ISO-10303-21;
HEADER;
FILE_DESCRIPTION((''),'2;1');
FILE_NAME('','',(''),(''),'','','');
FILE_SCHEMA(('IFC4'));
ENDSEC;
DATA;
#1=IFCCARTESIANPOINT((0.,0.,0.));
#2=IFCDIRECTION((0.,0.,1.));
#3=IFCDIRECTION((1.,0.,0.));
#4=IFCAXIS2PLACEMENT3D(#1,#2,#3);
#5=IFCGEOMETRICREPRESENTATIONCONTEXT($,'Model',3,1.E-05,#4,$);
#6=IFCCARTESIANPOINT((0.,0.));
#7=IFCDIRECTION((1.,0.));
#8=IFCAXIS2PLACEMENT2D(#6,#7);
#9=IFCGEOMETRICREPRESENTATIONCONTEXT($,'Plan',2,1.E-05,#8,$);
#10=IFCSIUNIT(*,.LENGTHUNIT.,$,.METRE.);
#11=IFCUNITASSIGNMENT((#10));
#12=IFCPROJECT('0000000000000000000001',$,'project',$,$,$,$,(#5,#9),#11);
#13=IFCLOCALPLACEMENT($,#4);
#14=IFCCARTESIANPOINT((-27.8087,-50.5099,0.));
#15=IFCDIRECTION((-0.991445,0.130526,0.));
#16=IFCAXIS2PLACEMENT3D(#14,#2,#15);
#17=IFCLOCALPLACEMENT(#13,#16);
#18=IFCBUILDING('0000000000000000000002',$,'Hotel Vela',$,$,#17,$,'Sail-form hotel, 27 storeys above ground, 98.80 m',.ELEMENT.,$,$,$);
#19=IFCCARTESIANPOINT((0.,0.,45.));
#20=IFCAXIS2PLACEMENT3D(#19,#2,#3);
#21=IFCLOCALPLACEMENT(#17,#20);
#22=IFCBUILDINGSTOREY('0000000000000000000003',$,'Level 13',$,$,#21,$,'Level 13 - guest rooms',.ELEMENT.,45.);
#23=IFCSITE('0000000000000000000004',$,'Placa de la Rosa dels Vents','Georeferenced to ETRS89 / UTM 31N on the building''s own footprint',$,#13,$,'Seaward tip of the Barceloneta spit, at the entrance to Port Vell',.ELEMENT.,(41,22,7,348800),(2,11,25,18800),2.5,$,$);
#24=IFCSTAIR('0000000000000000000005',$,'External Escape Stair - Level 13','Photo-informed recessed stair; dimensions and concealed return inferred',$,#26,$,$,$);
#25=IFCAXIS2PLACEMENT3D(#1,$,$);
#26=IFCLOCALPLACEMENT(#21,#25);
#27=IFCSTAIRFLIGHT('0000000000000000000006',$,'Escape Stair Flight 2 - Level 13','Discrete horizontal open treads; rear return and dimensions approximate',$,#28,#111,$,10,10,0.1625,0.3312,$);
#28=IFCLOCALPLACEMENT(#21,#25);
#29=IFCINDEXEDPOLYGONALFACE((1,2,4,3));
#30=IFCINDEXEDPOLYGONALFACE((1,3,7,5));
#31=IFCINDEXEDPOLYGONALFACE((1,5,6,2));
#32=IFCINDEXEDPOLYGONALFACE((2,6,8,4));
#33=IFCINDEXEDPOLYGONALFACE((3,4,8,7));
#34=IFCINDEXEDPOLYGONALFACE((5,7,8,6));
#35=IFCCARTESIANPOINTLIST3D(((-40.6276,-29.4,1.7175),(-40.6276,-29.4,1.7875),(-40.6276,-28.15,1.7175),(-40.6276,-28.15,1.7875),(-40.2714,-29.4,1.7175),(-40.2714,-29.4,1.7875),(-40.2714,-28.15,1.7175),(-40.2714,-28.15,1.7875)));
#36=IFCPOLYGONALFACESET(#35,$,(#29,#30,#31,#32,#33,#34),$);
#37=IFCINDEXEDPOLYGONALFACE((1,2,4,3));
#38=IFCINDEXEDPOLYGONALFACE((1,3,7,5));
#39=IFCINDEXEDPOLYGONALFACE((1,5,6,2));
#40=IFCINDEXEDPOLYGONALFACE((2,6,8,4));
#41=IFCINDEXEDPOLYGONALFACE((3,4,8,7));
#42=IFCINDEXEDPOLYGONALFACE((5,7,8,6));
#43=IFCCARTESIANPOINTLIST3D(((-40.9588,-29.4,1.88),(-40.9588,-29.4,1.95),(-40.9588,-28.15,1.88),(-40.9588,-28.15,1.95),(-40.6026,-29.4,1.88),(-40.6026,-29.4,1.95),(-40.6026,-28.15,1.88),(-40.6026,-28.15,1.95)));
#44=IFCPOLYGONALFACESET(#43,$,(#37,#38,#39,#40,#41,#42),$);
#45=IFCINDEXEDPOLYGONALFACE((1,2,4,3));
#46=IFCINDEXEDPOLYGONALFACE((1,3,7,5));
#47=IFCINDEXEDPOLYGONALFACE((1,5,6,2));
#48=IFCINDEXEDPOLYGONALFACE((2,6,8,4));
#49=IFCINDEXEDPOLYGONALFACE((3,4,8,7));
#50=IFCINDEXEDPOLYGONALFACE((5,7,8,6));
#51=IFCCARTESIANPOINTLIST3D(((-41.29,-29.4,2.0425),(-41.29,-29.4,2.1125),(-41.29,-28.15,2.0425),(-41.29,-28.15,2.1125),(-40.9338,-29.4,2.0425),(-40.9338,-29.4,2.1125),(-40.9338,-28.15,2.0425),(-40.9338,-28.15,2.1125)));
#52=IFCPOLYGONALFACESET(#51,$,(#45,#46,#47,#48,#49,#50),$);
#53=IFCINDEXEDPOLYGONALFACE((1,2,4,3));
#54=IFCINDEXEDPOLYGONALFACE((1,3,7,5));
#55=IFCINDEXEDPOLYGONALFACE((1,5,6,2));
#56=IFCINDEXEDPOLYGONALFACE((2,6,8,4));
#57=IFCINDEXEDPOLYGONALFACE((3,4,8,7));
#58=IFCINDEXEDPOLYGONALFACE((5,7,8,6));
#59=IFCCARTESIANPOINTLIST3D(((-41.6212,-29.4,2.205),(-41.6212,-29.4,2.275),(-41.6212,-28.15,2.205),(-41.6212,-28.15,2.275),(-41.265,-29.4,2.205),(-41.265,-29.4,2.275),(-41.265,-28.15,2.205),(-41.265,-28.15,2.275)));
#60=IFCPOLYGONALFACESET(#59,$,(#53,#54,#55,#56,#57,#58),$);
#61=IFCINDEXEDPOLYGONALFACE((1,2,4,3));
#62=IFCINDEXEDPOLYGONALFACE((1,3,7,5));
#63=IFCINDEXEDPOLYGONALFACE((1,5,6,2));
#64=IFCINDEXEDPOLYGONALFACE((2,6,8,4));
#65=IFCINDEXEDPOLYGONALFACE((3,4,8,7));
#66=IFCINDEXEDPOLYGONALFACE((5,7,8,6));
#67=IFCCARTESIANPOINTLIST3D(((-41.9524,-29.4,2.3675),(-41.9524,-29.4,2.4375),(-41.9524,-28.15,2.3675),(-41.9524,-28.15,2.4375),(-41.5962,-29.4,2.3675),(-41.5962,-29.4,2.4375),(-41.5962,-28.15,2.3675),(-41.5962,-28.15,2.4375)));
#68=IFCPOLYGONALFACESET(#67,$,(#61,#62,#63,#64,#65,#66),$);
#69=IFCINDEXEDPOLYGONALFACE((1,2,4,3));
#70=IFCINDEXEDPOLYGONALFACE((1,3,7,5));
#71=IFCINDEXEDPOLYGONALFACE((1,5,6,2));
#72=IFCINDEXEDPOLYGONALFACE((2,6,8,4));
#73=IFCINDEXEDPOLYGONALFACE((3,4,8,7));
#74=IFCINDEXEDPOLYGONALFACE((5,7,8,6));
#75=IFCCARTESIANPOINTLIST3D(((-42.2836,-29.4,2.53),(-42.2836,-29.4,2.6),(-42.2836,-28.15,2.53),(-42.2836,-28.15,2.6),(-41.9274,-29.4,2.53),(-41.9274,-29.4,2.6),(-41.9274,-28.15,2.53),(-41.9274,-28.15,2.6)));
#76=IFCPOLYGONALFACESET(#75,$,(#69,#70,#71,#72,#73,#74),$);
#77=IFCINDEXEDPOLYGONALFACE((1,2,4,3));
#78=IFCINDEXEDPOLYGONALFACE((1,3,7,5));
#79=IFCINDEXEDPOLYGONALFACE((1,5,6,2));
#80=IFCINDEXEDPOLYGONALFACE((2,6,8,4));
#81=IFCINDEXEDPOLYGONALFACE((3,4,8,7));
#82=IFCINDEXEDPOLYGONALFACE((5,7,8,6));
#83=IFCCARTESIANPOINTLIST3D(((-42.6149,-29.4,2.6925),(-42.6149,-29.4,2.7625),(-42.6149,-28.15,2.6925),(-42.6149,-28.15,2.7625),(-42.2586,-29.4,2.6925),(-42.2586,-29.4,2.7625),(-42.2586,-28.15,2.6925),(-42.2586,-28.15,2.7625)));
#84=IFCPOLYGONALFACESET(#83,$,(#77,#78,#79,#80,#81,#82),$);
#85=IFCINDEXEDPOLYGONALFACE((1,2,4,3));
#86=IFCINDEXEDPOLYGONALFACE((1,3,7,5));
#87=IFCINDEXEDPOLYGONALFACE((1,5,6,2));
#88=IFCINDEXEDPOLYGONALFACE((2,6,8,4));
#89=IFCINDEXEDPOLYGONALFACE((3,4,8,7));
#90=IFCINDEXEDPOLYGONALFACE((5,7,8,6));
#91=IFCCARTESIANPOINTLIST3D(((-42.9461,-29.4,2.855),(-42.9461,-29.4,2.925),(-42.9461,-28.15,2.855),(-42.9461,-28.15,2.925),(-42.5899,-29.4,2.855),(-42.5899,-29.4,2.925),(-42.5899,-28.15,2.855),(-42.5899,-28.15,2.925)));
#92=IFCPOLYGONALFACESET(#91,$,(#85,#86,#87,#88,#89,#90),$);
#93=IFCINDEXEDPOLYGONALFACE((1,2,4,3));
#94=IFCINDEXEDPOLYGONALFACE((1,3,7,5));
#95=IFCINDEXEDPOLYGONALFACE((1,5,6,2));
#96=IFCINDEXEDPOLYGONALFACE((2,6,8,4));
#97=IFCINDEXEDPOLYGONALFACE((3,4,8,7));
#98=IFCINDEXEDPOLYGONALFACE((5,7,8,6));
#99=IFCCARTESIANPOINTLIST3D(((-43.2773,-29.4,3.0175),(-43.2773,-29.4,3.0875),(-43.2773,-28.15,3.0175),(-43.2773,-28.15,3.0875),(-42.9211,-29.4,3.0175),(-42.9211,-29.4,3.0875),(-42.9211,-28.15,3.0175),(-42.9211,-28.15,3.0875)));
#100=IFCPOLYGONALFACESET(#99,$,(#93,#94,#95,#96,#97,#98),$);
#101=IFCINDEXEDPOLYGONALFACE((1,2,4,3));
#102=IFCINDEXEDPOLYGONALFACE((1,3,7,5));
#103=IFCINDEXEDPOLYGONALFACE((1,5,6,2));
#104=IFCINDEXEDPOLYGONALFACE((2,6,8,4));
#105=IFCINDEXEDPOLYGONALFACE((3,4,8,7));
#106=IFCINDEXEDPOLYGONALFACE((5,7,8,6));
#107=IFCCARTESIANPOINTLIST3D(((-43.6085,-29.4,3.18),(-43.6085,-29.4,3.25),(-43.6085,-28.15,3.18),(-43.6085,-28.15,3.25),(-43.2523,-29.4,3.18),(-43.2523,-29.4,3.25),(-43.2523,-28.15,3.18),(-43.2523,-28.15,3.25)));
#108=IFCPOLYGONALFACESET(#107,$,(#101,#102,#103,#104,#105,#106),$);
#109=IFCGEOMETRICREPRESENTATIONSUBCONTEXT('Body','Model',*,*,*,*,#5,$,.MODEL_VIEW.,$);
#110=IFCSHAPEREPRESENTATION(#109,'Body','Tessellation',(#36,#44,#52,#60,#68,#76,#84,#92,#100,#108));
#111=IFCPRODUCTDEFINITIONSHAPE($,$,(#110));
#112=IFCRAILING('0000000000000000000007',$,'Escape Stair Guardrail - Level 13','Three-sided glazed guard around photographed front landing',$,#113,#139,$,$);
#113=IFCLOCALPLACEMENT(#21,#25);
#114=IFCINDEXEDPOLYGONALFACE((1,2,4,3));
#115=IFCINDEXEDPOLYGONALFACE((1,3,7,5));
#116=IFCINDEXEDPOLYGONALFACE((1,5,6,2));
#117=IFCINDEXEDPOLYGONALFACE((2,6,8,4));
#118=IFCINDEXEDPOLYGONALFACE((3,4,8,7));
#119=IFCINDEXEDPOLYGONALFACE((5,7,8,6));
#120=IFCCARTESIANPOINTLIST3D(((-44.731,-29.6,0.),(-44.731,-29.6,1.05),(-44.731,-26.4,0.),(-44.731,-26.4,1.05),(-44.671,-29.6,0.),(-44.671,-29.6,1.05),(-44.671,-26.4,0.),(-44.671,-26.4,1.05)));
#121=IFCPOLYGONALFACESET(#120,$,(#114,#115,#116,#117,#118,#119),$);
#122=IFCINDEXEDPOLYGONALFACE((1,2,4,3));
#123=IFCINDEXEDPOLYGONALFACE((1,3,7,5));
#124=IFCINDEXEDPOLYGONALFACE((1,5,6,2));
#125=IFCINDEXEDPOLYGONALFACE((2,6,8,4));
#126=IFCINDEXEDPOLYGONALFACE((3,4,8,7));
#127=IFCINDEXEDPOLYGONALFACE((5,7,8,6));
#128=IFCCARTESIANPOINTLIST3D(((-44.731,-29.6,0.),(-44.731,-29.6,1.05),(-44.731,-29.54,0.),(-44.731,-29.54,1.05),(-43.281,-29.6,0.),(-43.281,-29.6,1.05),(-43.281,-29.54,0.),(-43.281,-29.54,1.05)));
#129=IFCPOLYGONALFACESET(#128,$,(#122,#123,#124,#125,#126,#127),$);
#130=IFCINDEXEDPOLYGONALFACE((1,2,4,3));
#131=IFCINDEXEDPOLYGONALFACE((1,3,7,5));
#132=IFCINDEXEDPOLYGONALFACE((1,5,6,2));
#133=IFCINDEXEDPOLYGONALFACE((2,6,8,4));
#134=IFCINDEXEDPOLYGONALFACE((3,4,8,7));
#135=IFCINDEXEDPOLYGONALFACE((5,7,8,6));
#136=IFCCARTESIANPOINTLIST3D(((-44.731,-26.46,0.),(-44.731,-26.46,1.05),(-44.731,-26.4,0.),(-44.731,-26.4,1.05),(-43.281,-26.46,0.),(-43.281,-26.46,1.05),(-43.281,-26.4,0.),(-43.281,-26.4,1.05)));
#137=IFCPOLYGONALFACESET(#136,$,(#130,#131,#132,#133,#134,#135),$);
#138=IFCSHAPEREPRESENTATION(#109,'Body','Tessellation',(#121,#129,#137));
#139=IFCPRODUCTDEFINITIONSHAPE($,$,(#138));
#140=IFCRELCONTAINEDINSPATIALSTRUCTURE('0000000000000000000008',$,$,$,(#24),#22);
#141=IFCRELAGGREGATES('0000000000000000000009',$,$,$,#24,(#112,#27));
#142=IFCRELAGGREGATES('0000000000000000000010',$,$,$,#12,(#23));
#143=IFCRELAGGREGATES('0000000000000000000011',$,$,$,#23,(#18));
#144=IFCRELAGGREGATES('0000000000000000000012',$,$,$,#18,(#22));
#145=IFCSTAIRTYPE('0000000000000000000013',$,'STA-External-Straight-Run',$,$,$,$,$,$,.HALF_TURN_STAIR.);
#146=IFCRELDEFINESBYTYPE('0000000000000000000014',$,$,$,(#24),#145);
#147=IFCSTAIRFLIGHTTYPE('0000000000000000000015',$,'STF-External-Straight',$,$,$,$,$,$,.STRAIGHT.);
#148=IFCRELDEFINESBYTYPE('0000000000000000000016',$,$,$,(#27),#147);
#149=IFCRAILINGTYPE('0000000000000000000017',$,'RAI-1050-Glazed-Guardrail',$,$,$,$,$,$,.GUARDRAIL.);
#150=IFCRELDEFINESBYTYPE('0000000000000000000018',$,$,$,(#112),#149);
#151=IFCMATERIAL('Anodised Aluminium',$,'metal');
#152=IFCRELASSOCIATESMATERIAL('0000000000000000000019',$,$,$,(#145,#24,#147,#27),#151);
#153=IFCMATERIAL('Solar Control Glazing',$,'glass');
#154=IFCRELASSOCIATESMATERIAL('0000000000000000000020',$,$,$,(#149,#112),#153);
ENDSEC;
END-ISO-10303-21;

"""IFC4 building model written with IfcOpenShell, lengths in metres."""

from ifc_helpers import new_model, si_unit, frame, origin_with_axes, origin_2d_with_axis, place, context, subcontext, project, spatial, line, indexed_curve, outline, extrude, material, type_object, element, aggregate, save


model = new_model("IFC4")

# Units and contexts
model_context = context("Model", 3, precision=1e-05, world=origin_with_axes())
plan_context = context("Plan", 2, precision=1e-05, world=origin_2d_with_axis())
body_context = subcontext(model_context, "Body", "Model", "MODEL_VIEW")
ifc_project = project(units=[si_unit("LENGTHUNIT", "METRE")], contexts=[model_context, plan_context])

# Site, building, storey
site_placement = place(None, origin_with_axes())
site = spatial("IfcSite", under=ifc_project, at=site_placement, Name="Placa de la Rosa dels Vents", Description="Georeferenced to ETRS89 / UTM 31N on the building's own footprint", LongName="Seaward tip of the Barceloneta spit, at the entrance to Port Vell", CompositionType="ELEMENT", RefLatitude=(41, 22, 7, 348800), RefLongitude=(2, 11, 25, 18800), RefElevation=2.5)
building_placement = place(site_placement, frame((-27.8087, -50.5099, 0.0), z_axis=(0.0, 0.0, 1.0), x_axis=(-0.991445, 0.130526, 0.0)))
building = spatial("IfcBuilding", under=site, at=building_placement, Name="Hotel Vela", LongName="Sail-form hotel, 27 storeys above ground, 98.80 m", CompositionType="ELEMENT")
storey_placement = place(building_placement, frame((0.0, 0.0, 45.0), z_axis=(0.0, 0.0, 1.0), x_axis=(1.0, 0.0, 0.0)))
storey = spatial("IfcBuildingStorey", under=building, at=storey_placement, Name="Level 13", LongName="Level 13 - guest rooms", CompositionType="ELEMENT", Elevation=45.0)

# Stair
ifc_material_1 = material(Name="Anodised Aluminium", Category="metal")
stair_type = type_object("IfcStairType", Name="STA-External-Straight-Run", PredefinedType="HALF_TURN_STAIR", material=ifc_material_1)
stair_placement = place(storey_placement, frame((0.0, 0.0, -45.0), z_axis=(0.0, 0.0, 1.0), x_axis=(1.0, 0.0, 0.0)))
stair = element("IfcStair", 1, at=stair_placement, inside=storey, type_object=stair_type, material=ifc_material_1, Name="External Escape Stair - Level 13", Description="Photo-informed recessed stair; dimensions and concealed return inferred")

# Stair flight
stair_flight_type = type_object("IfcStairFlightType", Name="STF-External-Straight", PredefinedType="STRAIGHT", material=ifc_material_1)
stair_flight_1_placement = place(stair_placement, origin_with_axes())
stair_flight_1 = element("IfcStairFlight", 2, at=stair_flight_1_placement, type_object=stair_flight_type, material=ifc_material_1, Name="Escape Stair Flight 2 - Level 13", Description="Discrete horizontal open treads; rear return and dimensions approximate", NumberOfRisers=10, NumberOfTreads=10, RiserHeight=0.1625, TreadLength=0.3312, context=body_context, shape_type="SweptSolid", body=[
    extrude(outline(indexed_curve([(0.0, 0.0), (0.3562, 0.0), (0.3562, 1.25), (0.0, 1.25)], segments=[line(1, 2, 3, 4, 1)])), frame((-40.6276, -29.4, 46.7175), z_axis=(0.0, 0.0, 1.0), x_axis=(1.0, 0.0, 0.0)), (0.0, 0.0, 1.0), 0.07),
    extrude(outline(indexed_curve([(0.0, 0.0), (0.3562, 0.0), (0.3562, 1.25), (0.0, 1.25)], segments=[line(1, 2, 3, 4, 1)])), frame((-40.9588, -29.4, 46.88), z_axis=(0.0, 0.0, 1.0), x_axis=(1.0, 0.0, 0.0)), (0.0, 0.0, 1.0), 0.07),
    extrude(outline(indexed_curve([(0.0, 0.0), (0.3562, 0.0), (0.3562, 1.25), (0.0, 1.25)], segments=[line(1, 2, 3, 4, 1)])), frame((-41.29, -29.4, 47.0425), z_axis=(0.0, 0.0, 1.0), x_axis=(1.0, 0.0, 0.0)), (0.0, 0.0, 1.0), 0.07),
    extrude(outline(indexed_curve([(0.0, 0.0), (0.3562, 0.0), (0.3562, 1.25), (0.0, 1.25)], segments=[line(1, 2, 3, 4, 1)])), frame((-41.6212, -29.4, 47.205), z_axis=(0.0, 0.0, 1.0), x_axis=(1.0, 0.0, 0.0)), (0.0, 0.0, 1.0), 0.07),
    extrude(outline(indexed_curve([(0.0, 0.0), (0.3562, 0.0), (0.3562, 1.25), (0.0, 1.25)], segments=[line(1, 2, 3, 4, 1)])), frame((-41.9524, -29.4, 47.3675), z_axis=(0.0, 0.0, 1.0), x_axis=(1.0, 0.0, 0.0)), (0.0, 0.0, 1.0), 0.07),
    extrude(outline(indexed_curve([(0.0, 0.0), (0.3562, 0.0), (0.3562, 1.25), (0.0, 1.25)], segments=[line(1, 2, 3, 4, 1)])), frame((-42.2836, -29.4, 47.53), z_axis=(0.0, 0.0, 1.0), x_axis=(1.0, 0.0, 0.0)), (0.0, 0.0, 1.0), 0.07),
    extrude(outline(indexed_curve([(0.0, 0.0), (0.3562, 0.0), (0.3562, 1.25), (0.0, 1.25)], segments=[line(1, 2, 3, 4, 1)])), frame((-42.6149, -29.4, 47.6925), z_axis=(0.0, 0.0, 1.0), x_axis=(1.0, 0.0, 0.0)), (0.0, 0.0, 1.0), 0.07),
    extrude(outline(indexed_curve([(0.0, 0.0), (0.3562, 0.0), (0.3562, 1.25), (0.0, 1.25)], segments=[line(1, 2, 3, 4, 1)])), frame((-42.9461, -29.4, 47.855), z_axis=(0.0, 0.0, 1.0), x_axis=(1.0, 0.0, 0.0)), (0.0, 0.0, 1.0), 0.07),
    extrude(outline(indexed_curve([(0.0, 0.0), (0.3562, 0.0), (0.3562, 1.25), (0.0, 1.25)], segments=[line(1, 2, 3, 4, 1)])), frame((-43.2773, -29.4, 48.0175), z_axis=(0.0, 0.0, 1.0), x_axis=(1.0, 0.0, 0.0)), (0.0, 0.0, 1.0), 0.07),
    extrude(outline(indexed_curve([(0.0, 0.0), (0.3562, 0.0), (0.3562, 1.25), (0.0, 1.25)], segments=[line(1, 2, 3, 4, 1)])), frame((-43.6085, -29.4, 48.18), z_axis=(0.0, 0.0, 1.0), x_axis=(1.0, 0.0, 0.0)), (0.0, 0.0, 1.0), 0.07),
])

# Railing
ifc_material_2 = material(Name="Solar Control Glazing", Category="glass")
railing_type = type_object("IfcRailingType", Name="RAI-1050-Glazed-Guardrail", PredefinedType="GUARDRAIL", material=ifc_material_2)
railing_placement = place(stair_placement, origin_with_axes())
railing = element("IfcRailing", 3, at=railing_placement, type_object=railing_type, material=ifc_material_2, Name="Escape Stair Guardrail - Level 13", Description="Three-sided glazed guard around photographed front landing", context=body_context, shape_type="SweptSolid", body=[
    extrude(outline(indexed_curve([(0.0, 0.0), (0.06, 0.0), (0.06, 3.2), (0.0, 3.2)], segments=[line(1, 2, 3, 4, 1)])), frame((-44.731, -29.6, 45.0), z_axis=(0.0, 0.0, 1.0), x_axis=(1.0, 0.0, 0.0)), (0.0, 0.0, 1.0), 1.05),
    extrude(outline(indexed_curve([(0.0, 0.0), (1.45, 0.0), (1.45, 0.06), (0.0, 0.06)], segments=[line(1, 2, 3, 4, 1)])), frame((-44.731, -29.6, 45.0), z_axis=(0.0, 0.0, 1.0), x_axis=(1.0, 0.0, 0.0)), (0.0, 0.0, 1.0), 1.05),
    extrude(outline(indexed_curve([(0.0, 0.0), (1.45, 0.0), (1.45, 0.06), (0.0, 0.06)], segments=[line(1, 2, 3, 4, 1)])), frame((-44.731, -26.46, 45.0), z_axis=(0.0, 0.0, 1.0), x_axis=(1.0, 0.0, 0.0)), (0.0, 0.0, 1.0), 1.05),
])
aggregate(stair, [railing, stair_flight_1])

save(model, "model.ifc")
